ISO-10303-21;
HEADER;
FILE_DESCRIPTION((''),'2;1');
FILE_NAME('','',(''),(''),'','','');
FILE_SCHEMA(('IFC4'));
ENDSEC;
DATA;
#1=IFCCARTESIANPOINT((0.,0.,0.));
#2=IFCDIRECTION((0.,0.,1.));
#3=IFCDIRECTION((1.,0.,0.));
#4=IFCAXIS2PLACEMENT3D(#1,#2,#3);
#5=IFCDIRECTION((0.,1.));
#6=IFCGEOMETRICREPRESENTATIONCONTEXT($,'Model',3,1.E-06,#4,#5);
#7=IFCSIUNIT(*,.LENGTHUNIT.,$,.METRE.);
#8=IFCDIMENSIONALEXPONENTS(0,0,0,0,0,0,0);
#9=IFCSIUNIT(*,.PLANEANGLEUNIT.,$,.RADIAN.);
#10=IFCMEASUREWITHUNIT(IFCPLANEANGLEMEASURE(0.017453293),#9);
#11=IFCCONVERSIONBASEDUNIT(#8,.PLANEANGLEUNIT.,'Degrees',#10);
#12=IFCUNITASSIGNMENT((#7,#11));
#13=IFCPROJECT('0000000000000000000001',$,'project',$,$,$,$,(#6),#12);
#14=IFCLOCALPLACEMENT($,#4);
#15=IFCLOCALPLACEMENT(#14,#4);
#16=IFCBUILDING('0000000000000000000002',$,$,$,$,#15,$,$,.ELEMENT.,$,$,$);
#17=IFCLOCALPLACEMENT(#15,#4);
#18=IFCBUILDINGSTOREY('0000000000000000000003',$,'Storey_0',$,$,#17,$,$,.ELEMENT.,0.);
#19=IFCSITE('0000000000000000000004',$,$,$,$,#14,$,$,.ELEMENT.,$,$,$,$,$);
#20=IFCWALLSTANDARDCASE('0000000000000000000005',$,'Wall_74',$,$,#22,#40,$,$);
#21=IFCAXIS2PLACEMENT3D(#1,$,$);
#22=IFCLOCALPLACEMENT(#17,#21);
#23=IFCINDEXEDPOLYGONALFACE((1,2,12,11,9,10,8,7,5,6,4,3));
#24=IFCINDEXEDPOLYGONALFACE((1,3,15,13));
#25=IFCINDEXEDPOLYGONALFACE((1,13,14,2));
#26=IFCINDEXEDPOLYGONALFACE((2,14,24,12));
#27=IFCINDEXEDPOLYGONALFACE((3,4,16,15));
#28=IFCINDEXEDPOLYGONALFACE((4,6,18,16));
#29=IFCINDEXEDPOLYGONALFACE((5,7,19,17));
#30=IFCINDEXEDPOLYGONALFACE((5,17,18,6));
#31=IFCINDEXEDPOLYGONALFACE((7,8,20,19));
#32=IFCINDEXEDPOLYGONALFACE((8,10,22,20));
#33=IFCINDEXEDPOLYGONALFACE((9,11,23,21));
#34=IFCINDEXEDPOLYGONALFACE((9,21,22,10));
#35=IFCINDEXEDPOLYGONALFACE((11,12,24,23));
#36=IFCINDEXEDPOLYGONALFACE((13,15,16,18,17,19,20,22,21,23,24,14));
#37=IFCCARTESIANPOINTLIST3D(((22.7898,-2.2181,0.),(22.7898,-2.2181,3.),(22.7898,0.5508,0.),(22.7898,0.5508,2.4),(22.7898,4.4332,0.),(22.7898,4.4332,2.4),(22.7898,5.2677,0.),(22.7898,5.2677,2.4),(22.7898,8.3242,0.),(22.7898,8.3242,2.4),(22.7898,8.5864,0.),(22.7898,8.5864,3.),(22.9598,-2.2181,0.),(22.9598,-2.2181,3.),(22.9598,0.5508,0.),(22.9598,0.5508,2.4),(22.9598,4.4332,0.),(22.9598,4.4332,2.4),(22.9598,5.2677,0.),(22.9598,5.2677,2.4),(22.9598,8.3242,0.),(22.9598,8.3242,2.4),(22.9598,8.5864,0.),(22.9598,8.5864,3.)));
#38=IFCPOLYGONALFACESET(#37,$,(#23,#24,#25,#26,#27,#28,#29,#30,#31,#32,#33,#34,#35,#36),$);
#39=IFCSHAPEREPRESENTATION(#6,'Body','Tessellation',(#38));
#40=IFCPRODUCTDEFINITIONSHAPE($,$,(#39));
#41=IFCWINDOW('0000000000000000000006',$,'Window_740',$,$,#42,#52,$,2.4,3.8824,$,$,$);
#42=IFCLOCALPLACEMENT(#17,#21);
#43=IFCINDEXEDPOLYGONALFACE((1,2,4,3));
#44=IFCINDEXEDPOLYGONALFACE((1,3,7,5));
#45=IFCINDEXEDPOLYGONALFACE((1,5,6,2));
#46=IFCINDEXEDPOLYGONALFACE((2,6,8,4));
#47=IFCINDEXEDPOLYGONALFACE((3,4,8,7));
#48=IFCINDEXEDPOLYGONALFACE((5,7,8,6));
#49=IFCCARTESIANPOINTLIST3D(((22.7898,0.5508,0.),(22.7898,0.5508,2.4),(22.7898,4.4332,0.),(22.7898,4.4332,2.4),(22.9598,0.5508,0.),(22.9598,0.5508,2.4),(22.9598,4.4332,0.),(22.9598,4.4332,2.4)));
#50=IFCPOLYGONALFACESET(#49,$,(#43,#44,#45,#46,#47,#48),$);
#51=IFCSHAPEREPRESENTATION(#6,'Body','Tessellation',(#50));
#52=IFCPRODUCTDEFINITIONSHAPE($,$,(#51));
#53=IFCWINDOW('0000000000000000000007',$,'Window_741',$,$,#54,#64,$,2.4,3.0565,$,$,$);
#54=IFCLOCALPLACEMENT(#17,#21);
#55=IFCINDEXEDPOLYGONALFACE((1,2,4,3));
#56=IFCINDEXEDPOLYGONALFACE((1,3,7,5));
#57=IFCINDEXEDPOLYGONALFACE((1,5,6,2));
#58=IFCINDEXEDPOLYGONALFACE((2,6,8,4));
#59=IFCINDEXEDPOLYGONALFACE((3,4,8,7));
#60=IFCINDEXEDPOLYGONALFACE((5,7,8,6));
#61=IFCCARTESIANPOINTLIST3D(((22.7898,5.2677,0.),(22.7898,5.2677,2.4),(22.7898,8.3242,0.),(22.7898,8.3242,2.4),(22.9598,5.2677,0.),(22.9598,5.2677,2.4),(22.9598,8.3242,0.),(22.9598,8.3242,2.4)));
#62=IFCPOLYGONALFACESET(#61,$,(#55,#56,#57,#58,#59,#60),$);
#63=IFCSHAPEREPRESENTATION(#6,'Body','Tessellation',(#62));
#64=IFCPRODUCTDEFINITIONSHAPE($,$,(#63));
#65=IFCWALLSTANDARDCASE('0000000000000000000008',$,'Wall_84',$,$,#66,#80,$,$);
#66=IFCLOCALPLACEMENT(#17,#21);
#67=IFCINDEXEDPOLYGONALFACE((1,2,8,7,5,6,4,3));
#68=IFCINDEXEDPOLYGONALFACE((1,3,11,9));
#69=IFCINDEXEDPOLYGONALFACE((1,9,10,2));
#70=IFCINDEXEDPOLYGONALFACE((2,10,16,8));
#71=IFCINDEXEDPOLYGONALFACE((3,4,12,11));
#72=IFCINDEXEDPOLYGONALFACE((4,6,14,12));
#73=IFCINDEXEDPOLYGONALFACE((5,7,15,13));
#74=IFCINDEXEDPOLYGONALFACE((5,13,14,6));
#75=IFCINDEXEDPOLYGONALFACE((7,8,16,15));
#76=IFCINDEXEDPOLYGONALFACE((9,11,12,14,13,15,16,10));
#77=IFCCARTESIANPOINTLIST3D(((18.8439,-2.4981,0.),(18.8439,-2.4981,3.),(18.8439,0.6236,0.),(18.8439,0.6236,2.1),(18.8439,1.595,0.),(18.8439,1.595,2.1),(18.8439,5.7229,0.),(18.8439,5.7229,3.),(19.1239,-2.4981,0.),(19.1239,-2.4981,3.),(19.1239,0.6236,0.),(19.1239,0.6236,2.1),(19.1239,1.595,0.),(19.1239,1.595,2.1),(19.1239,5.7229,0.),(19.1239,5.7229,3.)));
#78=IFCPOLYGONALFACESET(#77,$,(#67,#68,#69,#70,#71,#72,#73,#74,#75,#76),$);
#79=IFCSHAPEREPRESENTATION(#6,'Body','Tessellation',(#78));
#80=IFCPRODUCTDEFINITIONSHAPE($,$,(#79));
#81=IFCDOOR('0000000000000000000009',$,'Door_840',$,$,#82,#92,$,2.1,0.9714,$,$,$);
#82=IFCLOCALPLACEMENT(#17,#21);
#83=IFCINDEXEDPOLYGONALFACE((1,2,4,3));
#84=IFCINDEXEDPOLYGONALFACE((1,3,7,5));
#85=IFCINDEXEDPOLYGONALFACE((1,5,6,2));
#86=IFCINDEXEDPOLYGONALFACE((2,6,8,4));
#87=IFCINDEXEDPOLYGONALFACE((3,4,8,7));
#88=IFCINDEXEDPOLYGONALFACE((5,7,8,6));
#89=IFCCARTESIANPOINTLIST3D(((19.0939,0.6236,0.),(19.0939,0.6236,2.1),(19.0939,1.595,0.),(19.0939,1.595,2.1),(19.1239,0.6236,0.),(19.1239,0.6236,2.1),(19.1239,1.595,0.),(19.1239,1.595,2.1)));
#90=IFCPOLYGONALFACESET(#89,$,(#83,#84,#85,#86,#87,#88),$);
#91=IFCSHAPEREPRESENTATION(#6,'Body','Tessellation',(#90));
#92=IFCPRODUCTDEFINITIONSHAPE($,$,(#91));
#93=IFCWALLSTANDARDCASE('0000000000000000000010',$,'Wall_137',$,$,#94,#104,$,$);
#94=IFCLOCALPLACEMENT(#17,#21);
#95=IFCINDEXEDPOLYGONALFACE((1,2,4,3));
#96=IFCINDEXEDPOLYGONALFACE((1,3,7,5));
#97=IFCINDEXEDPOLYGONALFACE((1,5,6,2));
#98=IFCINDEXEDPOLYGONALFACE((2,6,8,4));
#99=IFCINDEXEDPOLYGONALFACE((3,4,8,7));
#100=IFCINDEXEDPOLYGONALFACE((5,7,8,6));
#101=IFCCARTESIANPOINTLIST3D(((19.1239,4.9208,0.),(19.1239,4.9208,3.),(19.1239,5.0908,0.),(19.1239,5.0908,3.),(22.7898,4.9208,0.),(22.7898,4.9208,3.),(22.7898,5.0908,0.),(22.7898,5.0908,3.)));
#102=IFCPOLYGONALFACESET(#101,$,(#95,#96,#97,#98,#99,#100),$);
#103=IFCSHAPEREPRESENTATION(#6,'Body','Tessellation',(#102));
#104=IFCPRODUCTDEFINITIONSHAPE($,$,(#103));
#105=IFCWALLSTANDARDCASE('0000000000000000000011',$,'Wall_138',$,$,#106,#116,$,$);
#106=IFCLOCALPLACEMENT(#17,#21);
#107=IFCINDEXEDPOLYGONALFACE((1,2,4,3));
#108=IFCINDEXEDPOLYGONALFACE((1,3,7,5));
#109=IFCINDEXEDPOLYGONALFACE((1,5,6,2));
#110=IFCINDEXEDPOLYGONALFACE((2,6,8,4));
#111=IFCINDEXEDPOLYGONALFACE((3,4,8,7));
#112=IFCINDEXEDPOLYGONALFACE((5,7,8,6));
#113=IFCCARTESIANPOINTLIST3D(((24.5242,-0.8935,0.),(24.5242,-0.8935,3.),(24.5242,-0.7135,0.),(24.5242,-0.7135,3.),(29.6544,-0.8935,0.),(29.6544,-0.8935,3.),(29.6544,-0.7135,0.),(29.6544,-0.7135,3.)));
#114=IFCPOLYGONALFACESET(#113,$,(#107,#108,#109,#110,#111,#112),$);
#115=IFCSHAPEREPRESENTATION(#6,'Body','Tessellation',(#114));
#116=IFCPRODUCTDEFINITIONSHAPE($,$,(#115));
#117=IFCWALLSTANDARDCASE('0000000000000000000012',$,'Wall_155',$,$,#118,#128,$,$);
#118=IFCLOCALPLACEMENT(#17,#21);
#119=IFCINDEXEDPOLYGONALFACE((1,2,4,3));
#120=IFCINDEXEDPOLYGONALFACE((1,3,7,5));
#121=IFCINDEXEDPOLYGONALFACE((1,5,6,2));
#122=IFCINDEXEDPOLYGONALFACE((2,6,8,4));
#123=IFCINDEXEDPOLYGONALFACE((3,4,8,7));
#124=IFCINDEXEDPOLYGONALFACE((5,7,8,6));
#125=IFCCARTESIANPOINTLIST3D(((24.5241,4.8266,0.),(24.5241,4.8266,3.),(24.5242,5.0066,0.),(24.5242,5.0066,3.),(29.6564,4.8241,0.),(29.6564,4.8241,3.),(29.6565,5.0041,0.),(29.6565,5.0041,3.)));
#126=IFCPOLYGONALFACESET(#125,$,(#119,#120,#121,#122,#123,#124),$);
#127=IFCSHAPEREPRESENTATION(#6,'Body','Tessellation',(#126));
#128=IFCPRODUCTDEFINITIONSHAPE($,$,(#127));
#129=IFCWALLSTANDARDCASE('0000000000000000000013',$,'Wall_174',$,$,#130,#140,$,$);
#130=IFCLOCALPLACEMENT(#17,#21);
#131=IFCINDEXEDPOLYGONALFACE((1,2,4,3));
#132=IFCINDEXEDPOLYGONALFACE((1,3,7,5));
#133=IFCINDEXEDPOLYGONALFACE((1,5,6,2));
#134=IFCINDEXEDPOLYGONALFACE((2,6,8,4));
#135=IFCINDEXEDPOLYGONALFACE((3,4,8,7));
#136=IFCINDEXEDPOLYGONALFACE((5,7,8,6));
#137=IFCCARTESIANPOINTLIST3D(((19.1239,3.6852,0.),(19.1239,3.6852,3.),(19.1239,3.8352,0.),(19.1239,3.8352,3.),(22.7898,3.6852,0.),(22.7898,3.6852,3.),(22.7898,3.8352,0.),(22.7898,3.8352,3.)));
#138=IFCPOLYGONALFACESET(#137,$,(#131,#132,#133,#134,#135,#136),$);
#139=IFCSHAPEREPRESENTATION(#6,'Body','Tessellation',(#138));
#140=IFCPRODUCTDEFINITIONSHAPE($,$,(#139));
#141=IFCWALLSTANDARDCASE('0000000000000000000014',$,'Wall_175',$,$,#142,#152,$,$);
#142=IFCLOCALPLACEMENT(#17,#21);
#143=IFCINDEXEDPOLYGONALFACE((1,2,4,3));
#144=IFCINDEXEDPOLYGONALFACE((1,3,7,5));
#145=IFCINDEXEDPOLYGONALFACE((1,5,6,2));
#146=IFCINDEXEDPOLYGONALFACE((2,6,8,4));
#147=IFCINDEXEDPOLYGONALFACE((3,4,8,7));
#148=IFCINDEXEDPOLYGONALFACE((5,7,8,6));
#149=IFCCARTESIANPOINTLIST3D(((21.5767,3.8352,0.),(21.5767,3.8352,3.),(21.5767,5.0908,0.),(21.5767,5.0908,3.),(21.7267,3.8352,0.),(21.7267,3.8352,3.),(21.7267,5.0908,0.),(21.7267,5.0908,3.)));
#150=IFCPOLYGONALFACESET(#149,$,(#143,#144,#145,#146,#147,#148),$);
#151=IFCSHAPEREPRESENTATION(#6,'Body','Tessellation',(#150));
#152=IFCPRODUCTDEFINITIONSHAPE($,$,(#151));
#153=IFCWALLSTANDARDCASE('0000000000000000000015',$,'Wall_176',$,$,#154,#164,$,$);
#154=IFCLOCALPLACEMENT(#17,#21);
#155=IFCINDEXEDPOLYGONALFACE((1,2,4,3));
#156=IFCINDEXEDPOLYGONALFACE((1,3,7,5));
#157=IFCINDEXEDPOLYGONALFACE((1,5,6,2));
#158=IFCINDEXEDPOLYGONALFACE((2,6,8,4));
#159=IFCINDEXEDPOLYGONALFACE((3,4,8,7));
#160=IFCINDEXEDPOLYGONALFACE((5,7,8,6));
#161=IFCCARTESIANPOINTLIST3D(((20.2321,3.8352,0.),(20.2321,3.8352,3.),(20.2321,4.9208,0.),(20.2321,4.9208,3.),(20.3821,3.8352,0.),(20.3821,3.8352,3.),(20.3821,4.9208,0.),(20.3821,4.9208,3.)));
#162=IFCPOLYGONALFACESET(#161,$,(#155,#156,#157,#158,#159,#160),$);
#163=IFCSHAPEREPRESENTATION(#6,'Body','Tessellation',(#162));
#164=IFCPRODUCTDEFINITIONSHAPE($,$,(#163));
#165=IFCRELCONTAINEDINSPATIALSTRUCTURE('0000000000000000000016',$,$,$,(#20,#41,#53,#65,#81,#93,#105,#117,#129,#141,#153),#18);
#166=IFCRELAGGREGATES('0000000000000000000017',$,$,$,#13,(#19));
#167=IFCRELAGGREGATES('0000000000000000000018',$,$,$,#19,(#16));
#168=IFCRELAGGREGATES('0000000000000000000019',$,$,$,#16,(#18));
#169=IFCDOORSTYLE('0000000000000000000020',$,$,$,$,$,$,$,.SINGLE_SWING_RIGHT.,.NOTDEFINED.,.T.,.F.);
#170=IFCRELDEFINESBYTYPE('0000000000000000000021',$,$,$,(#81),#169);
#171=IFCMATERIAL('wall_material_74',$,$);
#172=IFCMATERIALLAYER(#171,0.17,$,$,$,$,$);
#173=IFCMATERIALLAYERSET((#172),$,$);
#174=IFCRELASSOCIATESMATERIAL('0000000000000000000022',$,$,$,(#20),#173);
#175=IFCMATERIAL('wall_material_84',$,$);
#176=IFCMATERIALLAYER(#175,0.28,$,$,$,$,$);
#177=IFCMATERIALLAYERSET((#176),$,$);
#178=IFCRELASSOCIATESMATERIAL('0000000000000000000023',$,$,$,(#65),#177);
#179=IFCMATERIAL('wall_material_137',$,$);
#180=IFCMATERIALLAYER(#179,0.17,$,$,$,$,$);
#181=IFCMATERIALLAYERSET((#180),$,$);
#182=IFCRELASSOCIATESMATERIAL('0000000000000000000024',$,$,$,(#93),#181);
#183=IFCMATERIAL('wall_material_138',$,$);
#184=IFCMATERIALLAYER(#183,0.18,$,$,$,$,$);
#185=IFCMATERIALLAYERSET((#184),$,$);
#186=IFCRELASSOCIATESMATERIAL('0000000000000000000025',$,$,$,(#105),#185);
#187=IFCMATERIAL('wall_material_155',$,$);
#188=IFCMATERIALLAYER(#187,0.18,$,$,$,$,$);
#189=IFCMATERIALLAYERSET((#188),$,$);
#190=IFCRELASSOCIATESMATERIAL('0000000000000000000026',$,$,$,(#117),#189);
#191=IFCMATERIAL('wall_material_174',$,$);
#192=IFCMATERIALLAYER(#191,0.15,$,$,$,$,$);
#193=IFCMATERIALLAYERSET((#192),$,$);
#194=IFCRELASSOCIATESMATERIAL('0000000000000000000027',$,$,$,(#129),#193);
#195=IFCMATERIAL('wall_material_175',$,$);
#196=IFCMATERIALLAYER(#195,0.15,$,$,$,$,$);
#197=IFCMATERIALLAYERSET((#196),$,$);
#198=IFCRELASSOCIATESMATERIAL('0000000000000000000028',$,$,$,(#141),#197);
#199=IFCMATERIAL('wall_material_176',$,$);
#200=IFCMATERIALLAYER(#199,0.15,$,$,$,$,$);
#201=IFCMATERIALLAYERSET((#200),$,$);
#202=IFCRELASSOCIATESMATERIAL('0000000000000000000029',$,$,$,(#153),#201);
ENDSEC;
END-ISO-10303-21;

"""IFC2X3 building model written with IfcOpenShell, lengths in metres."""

from ifc_helpers import new_model, entity, si_unit, converted_unit, direction, frame, frame_2d, origin_with_axes, place, context, project, spatial, polyline, rectangle, outline, extrude, material, layer, layer_set, layer_usage, type_object, element, fill, save


model = new_model("IFC2X3")

# Units and contexts
model_context = context("Model", 3, precision=1e-06, world=origin_with_axes(), true_north=direction((0.0, 1.0)))
ifc_project = project(units=[si_unit("LENGTHUNIT", "METRE"), converted_unit("PLANEANGLEUNIT", "Degrees", entity("IfcPlaneAngleMeasure", 0.017453293), si_unit("PLANEANGLEUNIT", "RADIAN"), dimensions=[0, 0, 0, 0, 0, 0, 0])], contexts=[model_context])

# Site, building, storey
site_placement = place(None, origin_with_axes())
site = spatial("IfcSite", under=ifc_project, at=site_placement, CompositionType="ELEMENT")
building_placement = place(site_placement, origin_with_axes())
building = spatial("IfcBuilding", under=site, at=building_placement, CompositionType="ELEMENT")
storey_placement = place(building_placement, origin_with_axes())
storey = spatial("IfcBuildingStorey", under=building, at=storey_placement, Name="Storey_0", CompositionType="ELEMENT", Elevation=0.0)

# Wall, openings, windows
ifc_material_1 = material(Name="wall_material_74")
ifc_layer_1 = layer(ifc_material_1, 0.17)
ifc_layer_set_1 = layer_set([ifc_layer_1])
ifc_layer_usage_1 = layer_usage(ifc_layer_set_1, "AXIS2", "POSITIVE", 0.0)
wall_1_placement = place(storey_placement, frame((22.9598, -2.2181, 0.0), z_axis=(0.0, 0.0, 1.0), x_axis=(0.0, 1.0, 0.0)))
wall_1 = element("IfcWallStandardCase", 1, at=wall_1_placement, inside=storey, material=ifc_layer_usage_1, Name="Wall_74", context=model_context, shape_type="SweptSolid", body=[
    extrude(outline(polyline([(0.0, 0.17), (10.8045, 0.17), (10.8045, 0.0), (0.0, 0.0), (0.0, 0.17)])), origin_with_axes(), (0.0, 0.0, 1.0), 3.0),
])
opening_1_placement = place(wall_1_placement, frame((2.7689, 0.17, 0.0), z_axis=(0.0, 0.0, 1.0), x_axis=(1.0, 0.0, 0.0)))
opening_1 = element("IfcOpeningElement", 2, at=opening_1_placement, cuts=wall_1, context=model_context, shape_type="SweptSolid", body=[
    extrude(rectangle(XDim=3.8824, YDim=2.4, at=frame_2d((1.2, -1.9412), x_axis=(0.0, 1.0))), frame((0.0, 0.01, 0.0), z_axis=(0.0, -1.0, 0.0), x_axis=(0.0, 0.0, 1.0)), (0.0, 0.0, 1.0), 0.19),
])
opening_2_placement = place(wall_1_placement, frame((7.4858, 0.17, 0.0), z_axis=(0.0, 0.0, 1.0), x_axis=(1.0, 0.0, 0.0)))
opening_2 = element("IfcOpeningElement", 3, at=opening_2_placement, cuts=wall_1, context=model_context, shape_type="SweptSolid", body=[
    extrude(rectangle(XDim=3.0565, YDim=2.4, at=frame_2d((1.2, -1.5282), x_axis=(0.0, 1.0))), frame((0.0, 0.01, 0.0), z_axis=(0.0, -1.0, 0.0), x_axis=(0.0, 0.0, 1.0)), (0.0, 0.0, 1.0), 0.19),
])
window_1_placement = place(storey_placement, origin_with_axes())
window_1 = element("IfcWindow", 4, at=window_1_placement, inside=storey, Name="Window_740", OverallHeight=2.4, OverallWidth=3.8824, context=model_context, shape_type="SweptSolid", body=[
    extrude(outline(polyline([(22.7898, 0.5508), (22.7898, 4.4332), (22.9598, 4.4332), (22.9598, 0.5508), (22.7898, 0.5508)])), origin_with_axes(), (0.0, 0.0, 1.0), 2.4),
])
fill(opening_1, window_1)
window_2_placement = place(storey_placement, origin_with_axes())
window_2 = element("IfcWindow", 5, at=window_2_placement, inside=storey, Name="Window_741", OverallHeight=2.4, OverallWidth=3.0565, context=model_context, shape_type="SweptSolid", body=[
    extrude(outline(polyline([(22.7898, 5.2677), (22.7898, 8.3242), (22.9598, 8.3242), (22.9598, 5.2677), (22.7898, 5.2677)])), origin_with_axes(), (0.0, 0.0, 1.0), 2.4),
])
fill(opening_2, window_2)

# Wall, opening, door
ifc_material_2 = material(Name="wall_material_84")
ifc_layer_2 = layer(ifc_material_2, 0.28)
ifc_layer_set_2 = layer_set([ifc_layer_2])
ifc_layer_usage_2 = layer_usage(ifc_layer_set_2, "AXIS2", "POSITIVE", 0.0)
wall_2_placement = place(storey_placement, frame((18.8439, 5.7229, 0.0), z_axis=(0.0, 0.0, 1.0), x_axis=(0.0, -1.0, 0.0)))
wall_2 = element("IfcWallStandardCase", 6, at=wall_2_placement, inside=storey, material=ifc_layer_usage_2, Name="Wall_84", context=model_context, shape_type="SweptSolid", body=[
    extrude(outline(polyline([(0.0, 0.28), (8.221, 0.28), (8.221, 0.0), (0.0, 0.0), (0.0, 0.28)])), origin_with_axes(), (0.0, 0.0, 1.0), 3.0),
])
opening_3_placement = place(wall_2_placement, frame((4.1279, 0.28, 0.0), z_axis=(0.0, 0.0, 1.0), x_axis=(1.0, 0.0, 0.0)))
opening_3 = element("IfcOpeningElement", 7, at=opening_3_placement, cuts=wall_2, context=model_context, shape_type="SweptSolid", body=[
    extrude(rectangle(XDim=0.9714, YDim=2.1, at=frame_2d((1.05, -0.4857), x_axis=(0.0, 1.0))), frame((0.0, 0.01, 0.0), z_axis=(0.0, -1.0, 0.0), x_axis=(0.0, 0.0, 1.0)), (0.0, 0.0, 1.0), 0.3),
])
door_style = type_object("IfcDoorStyle", ConstructionType="NOTDEFINED", OperationType="SINGLE_SWING_RIGHT", ParameterTakesPrecedence=True, Sizeable=False)
door_placement = place(storey_placement, origin_with_axes())
door = element("IfcDoor", 8, at=door_placement, inside=storey, type_object=door_style, Name="Door_840", OverallHeight=2.1, OverallWidth=0.9714, context=model_context, shape_type="SweptSolid", body=[
    extrude(outline(polyline([(19.1239, 1.595), (19.1239, 0.6236), (19.0939, 0.6236), (19.0939, 1.595), (19.1239, 1.595)])), origin_with_axes(), (0.0, 0.0, 1.0), 2.1),
])
fill(opening_3, door)

# Walls
ifc_material_3 = material(Name="wall_material_137")
ifc_layer_3 = layer(ifc_material_3, 0.17)
ifc_layer_set_3 = layer_set([ifc_layer_3])
ifc_layer_usage_3 = layer_usage(ifc_layer_set_3, "AXIS2", "NEGATIVE", 0.0)
wall_3_placement = place(storey_placement, frame((19.1239, 5.0908, 0.0), z_axis=(0.0, 0.0, 1.0), x_axis=(1.0, 0.0, 0.0)))
element("IfcWallStandardCase", 9, at=wall_3_placement, inside=storey, material=ifc_layer_usage_3, Name="Wall_137", context=model_context, shape_type="SweptSolid", body=[
    extrude(outline(polyline([(0.0, 0.0), (3.6659, 0.0), (3.6659, -0.17), (0.0, -0.17), (0.0, 0.0)])), origin_with_axes(), (0.0, 0.0, 1.0), 3.0),
])
ifc_material_4 = material(Name="wall_material_138")
ifc_layer_4 = layer(ifc_material_4, 0.18)
ifc_layer_set_4 = layer_set([ifc_layer_4])
ifc_layer_usage_4 = layer_usage(ifc_layer_set_4, "AXIS2", "NEGATIVE", 0.0)
wall_4_placement = place(storey_placement, frame((24.5242, -0.7135, 0.0), z_axis=(0.0, 0.0, 1.0), x_axis=(1.0, 0.0, 0.0)))
element("IfcWallStandardCase", 10, at=wall_4_placement, inside=storey, material=ifc_layer_usage_4, Name="Wall_138", context=model_context, shape_type="SweptSolid", body=[
    extrude(outline(polyline([(0.0, 0.0), (5.1302, 0.0), (5.1302, -0.18), (0.0, -0.18), (0.0, 0.0)])), origin_with_axes(), (0.0, 0.0, 1.0), 3.0),
])
ifc_material_5 = material(Name="wall_material_155")
ifc_layer_5 = layer(ifc_material_5, 0.18)
ifc_layer_set_5 = layer_set([ifc_layer_5])
ifc_layer_usage_5 = layer_usage(ifc_layer_set_5, "AXIS2", "POSITIVE", 0.0)
wall_5_placement = place(storey_placement, frame((29.6565, 5.0041, 0.0), z_axis=(0.0, 0.0, 1.0), x_axis=(-1.0, 0.00049, 0.0)))
element("IfcWallStandardCase", 11, at=wall_5_placement, inside=storey, material=ifc_layer_usage_5, Name="Wall_155", context=model_context, shape_type="SweptSolid", body=[
    extrude(outline(polyline([(0.0, 0.18), (5.1323, 0.18), (5.1323, 0.0), (0.0, 0.0), (0.0, 0.18)])), origin_with_axes(), (0.0, 0.0, 1.0), 3.0),
])
ifc_material_6 = material(Name="wall_material_174")
ifc_layer_6 = layer(ifc_material_6, 0.15)
ifc_layer_set_6 = layer_set([ifc_layer_6])
ifc_layer_usage_6 = layer_usage(ifc_layer_set_6, "AXIS2", "NEGATIVE", 0.0)
wall_6_placement = place(storey_placement, frame((22.7898, 3.6852, 0.0), z_axis=(0.0, 0.0, 1.0), x_axis=(-1.0, 0.0, 0.0)))
element("IfcWallStandardCase", 12, at=wall_6_placement, inside=storey, material=ifc_layer_usage_6, Name="Wall_174", context=model_context, shape_type="SweptSolid", body=[
    extrude(outline(polyline([(0.0, 0.0), (3.6659, 0.0), (3.6659, -0.15), (0.0, -0.15), (0.0, 0.0)])), origin_with_axes(), (0.0, 0.0, 1.0), 3.0),
])
ifc_material_7 = material(Name="wall_material_175")
ifc_layer_7 = layer(ifc_material_7, 0.15)
ifc_layer_set_7 = layer_set([ifc_layer_7])
ifc_layer_usage_7 = layer_usage(ifc_layer_set_7, "AXIS2", "NEGATIVE", 0.0)
wall_7_placement = place(storey_placement, frame((21.7267, 5.0908, 0.0), z_axis=(0.0, 0.0, 1.0), x_axis=(0.0, -1.0, 0.0)))
element("IfcWallStandardCase", 13, at=wall_7_placement, inside=storey, material=ifc_layer_usage_7, Name="Wall_175", context=model_context, shape_type="SweptSolid", body=[
    extrude(outline(polyline([(0.0, 0.0), (1.2556, 0.0), (1.2556, -0.15), (0.0, -0.15), (0.0, 0.0)])), origin_with_axes(), (0.0, 0.0, 1.0), 3.0),
])
ifc_material_8 = material(Name="wall_material_176")
ifc_layer_8 = layer(ifc_material_8, 0.15)
ifc_layer_set_8 = layer_set([ifc_layer_8])
ifc_layer_usage_8 = layer_usage(ifc_layer_set_8, "AXIS2", "NEGATIVE", 0.0)
wall_8_placement = place(storey_placement, frame((20.3821, 4.9208, 0.0), z_axis=(0.0, 0.0, 1.0), x_axis=(0.0, -1.0, 0.0)))
element("IfcWallStandardCase", 14, at=wall_8_placement, inside=storey, material=ifc_layer_usage_8, Name="Wall_176", context=model_context, shape_type="SweptSolid", body=[
    extrude(outline(polyline([(0.0, 0.0), (1.0856, 0.0), (1.0856, -0.15), (0.0, -0.15), (0.0, 0.0)])), origin_with_axes(), (0.0, 0.0, 1.0), 3.0),
])

save(model, "model.ifc")
